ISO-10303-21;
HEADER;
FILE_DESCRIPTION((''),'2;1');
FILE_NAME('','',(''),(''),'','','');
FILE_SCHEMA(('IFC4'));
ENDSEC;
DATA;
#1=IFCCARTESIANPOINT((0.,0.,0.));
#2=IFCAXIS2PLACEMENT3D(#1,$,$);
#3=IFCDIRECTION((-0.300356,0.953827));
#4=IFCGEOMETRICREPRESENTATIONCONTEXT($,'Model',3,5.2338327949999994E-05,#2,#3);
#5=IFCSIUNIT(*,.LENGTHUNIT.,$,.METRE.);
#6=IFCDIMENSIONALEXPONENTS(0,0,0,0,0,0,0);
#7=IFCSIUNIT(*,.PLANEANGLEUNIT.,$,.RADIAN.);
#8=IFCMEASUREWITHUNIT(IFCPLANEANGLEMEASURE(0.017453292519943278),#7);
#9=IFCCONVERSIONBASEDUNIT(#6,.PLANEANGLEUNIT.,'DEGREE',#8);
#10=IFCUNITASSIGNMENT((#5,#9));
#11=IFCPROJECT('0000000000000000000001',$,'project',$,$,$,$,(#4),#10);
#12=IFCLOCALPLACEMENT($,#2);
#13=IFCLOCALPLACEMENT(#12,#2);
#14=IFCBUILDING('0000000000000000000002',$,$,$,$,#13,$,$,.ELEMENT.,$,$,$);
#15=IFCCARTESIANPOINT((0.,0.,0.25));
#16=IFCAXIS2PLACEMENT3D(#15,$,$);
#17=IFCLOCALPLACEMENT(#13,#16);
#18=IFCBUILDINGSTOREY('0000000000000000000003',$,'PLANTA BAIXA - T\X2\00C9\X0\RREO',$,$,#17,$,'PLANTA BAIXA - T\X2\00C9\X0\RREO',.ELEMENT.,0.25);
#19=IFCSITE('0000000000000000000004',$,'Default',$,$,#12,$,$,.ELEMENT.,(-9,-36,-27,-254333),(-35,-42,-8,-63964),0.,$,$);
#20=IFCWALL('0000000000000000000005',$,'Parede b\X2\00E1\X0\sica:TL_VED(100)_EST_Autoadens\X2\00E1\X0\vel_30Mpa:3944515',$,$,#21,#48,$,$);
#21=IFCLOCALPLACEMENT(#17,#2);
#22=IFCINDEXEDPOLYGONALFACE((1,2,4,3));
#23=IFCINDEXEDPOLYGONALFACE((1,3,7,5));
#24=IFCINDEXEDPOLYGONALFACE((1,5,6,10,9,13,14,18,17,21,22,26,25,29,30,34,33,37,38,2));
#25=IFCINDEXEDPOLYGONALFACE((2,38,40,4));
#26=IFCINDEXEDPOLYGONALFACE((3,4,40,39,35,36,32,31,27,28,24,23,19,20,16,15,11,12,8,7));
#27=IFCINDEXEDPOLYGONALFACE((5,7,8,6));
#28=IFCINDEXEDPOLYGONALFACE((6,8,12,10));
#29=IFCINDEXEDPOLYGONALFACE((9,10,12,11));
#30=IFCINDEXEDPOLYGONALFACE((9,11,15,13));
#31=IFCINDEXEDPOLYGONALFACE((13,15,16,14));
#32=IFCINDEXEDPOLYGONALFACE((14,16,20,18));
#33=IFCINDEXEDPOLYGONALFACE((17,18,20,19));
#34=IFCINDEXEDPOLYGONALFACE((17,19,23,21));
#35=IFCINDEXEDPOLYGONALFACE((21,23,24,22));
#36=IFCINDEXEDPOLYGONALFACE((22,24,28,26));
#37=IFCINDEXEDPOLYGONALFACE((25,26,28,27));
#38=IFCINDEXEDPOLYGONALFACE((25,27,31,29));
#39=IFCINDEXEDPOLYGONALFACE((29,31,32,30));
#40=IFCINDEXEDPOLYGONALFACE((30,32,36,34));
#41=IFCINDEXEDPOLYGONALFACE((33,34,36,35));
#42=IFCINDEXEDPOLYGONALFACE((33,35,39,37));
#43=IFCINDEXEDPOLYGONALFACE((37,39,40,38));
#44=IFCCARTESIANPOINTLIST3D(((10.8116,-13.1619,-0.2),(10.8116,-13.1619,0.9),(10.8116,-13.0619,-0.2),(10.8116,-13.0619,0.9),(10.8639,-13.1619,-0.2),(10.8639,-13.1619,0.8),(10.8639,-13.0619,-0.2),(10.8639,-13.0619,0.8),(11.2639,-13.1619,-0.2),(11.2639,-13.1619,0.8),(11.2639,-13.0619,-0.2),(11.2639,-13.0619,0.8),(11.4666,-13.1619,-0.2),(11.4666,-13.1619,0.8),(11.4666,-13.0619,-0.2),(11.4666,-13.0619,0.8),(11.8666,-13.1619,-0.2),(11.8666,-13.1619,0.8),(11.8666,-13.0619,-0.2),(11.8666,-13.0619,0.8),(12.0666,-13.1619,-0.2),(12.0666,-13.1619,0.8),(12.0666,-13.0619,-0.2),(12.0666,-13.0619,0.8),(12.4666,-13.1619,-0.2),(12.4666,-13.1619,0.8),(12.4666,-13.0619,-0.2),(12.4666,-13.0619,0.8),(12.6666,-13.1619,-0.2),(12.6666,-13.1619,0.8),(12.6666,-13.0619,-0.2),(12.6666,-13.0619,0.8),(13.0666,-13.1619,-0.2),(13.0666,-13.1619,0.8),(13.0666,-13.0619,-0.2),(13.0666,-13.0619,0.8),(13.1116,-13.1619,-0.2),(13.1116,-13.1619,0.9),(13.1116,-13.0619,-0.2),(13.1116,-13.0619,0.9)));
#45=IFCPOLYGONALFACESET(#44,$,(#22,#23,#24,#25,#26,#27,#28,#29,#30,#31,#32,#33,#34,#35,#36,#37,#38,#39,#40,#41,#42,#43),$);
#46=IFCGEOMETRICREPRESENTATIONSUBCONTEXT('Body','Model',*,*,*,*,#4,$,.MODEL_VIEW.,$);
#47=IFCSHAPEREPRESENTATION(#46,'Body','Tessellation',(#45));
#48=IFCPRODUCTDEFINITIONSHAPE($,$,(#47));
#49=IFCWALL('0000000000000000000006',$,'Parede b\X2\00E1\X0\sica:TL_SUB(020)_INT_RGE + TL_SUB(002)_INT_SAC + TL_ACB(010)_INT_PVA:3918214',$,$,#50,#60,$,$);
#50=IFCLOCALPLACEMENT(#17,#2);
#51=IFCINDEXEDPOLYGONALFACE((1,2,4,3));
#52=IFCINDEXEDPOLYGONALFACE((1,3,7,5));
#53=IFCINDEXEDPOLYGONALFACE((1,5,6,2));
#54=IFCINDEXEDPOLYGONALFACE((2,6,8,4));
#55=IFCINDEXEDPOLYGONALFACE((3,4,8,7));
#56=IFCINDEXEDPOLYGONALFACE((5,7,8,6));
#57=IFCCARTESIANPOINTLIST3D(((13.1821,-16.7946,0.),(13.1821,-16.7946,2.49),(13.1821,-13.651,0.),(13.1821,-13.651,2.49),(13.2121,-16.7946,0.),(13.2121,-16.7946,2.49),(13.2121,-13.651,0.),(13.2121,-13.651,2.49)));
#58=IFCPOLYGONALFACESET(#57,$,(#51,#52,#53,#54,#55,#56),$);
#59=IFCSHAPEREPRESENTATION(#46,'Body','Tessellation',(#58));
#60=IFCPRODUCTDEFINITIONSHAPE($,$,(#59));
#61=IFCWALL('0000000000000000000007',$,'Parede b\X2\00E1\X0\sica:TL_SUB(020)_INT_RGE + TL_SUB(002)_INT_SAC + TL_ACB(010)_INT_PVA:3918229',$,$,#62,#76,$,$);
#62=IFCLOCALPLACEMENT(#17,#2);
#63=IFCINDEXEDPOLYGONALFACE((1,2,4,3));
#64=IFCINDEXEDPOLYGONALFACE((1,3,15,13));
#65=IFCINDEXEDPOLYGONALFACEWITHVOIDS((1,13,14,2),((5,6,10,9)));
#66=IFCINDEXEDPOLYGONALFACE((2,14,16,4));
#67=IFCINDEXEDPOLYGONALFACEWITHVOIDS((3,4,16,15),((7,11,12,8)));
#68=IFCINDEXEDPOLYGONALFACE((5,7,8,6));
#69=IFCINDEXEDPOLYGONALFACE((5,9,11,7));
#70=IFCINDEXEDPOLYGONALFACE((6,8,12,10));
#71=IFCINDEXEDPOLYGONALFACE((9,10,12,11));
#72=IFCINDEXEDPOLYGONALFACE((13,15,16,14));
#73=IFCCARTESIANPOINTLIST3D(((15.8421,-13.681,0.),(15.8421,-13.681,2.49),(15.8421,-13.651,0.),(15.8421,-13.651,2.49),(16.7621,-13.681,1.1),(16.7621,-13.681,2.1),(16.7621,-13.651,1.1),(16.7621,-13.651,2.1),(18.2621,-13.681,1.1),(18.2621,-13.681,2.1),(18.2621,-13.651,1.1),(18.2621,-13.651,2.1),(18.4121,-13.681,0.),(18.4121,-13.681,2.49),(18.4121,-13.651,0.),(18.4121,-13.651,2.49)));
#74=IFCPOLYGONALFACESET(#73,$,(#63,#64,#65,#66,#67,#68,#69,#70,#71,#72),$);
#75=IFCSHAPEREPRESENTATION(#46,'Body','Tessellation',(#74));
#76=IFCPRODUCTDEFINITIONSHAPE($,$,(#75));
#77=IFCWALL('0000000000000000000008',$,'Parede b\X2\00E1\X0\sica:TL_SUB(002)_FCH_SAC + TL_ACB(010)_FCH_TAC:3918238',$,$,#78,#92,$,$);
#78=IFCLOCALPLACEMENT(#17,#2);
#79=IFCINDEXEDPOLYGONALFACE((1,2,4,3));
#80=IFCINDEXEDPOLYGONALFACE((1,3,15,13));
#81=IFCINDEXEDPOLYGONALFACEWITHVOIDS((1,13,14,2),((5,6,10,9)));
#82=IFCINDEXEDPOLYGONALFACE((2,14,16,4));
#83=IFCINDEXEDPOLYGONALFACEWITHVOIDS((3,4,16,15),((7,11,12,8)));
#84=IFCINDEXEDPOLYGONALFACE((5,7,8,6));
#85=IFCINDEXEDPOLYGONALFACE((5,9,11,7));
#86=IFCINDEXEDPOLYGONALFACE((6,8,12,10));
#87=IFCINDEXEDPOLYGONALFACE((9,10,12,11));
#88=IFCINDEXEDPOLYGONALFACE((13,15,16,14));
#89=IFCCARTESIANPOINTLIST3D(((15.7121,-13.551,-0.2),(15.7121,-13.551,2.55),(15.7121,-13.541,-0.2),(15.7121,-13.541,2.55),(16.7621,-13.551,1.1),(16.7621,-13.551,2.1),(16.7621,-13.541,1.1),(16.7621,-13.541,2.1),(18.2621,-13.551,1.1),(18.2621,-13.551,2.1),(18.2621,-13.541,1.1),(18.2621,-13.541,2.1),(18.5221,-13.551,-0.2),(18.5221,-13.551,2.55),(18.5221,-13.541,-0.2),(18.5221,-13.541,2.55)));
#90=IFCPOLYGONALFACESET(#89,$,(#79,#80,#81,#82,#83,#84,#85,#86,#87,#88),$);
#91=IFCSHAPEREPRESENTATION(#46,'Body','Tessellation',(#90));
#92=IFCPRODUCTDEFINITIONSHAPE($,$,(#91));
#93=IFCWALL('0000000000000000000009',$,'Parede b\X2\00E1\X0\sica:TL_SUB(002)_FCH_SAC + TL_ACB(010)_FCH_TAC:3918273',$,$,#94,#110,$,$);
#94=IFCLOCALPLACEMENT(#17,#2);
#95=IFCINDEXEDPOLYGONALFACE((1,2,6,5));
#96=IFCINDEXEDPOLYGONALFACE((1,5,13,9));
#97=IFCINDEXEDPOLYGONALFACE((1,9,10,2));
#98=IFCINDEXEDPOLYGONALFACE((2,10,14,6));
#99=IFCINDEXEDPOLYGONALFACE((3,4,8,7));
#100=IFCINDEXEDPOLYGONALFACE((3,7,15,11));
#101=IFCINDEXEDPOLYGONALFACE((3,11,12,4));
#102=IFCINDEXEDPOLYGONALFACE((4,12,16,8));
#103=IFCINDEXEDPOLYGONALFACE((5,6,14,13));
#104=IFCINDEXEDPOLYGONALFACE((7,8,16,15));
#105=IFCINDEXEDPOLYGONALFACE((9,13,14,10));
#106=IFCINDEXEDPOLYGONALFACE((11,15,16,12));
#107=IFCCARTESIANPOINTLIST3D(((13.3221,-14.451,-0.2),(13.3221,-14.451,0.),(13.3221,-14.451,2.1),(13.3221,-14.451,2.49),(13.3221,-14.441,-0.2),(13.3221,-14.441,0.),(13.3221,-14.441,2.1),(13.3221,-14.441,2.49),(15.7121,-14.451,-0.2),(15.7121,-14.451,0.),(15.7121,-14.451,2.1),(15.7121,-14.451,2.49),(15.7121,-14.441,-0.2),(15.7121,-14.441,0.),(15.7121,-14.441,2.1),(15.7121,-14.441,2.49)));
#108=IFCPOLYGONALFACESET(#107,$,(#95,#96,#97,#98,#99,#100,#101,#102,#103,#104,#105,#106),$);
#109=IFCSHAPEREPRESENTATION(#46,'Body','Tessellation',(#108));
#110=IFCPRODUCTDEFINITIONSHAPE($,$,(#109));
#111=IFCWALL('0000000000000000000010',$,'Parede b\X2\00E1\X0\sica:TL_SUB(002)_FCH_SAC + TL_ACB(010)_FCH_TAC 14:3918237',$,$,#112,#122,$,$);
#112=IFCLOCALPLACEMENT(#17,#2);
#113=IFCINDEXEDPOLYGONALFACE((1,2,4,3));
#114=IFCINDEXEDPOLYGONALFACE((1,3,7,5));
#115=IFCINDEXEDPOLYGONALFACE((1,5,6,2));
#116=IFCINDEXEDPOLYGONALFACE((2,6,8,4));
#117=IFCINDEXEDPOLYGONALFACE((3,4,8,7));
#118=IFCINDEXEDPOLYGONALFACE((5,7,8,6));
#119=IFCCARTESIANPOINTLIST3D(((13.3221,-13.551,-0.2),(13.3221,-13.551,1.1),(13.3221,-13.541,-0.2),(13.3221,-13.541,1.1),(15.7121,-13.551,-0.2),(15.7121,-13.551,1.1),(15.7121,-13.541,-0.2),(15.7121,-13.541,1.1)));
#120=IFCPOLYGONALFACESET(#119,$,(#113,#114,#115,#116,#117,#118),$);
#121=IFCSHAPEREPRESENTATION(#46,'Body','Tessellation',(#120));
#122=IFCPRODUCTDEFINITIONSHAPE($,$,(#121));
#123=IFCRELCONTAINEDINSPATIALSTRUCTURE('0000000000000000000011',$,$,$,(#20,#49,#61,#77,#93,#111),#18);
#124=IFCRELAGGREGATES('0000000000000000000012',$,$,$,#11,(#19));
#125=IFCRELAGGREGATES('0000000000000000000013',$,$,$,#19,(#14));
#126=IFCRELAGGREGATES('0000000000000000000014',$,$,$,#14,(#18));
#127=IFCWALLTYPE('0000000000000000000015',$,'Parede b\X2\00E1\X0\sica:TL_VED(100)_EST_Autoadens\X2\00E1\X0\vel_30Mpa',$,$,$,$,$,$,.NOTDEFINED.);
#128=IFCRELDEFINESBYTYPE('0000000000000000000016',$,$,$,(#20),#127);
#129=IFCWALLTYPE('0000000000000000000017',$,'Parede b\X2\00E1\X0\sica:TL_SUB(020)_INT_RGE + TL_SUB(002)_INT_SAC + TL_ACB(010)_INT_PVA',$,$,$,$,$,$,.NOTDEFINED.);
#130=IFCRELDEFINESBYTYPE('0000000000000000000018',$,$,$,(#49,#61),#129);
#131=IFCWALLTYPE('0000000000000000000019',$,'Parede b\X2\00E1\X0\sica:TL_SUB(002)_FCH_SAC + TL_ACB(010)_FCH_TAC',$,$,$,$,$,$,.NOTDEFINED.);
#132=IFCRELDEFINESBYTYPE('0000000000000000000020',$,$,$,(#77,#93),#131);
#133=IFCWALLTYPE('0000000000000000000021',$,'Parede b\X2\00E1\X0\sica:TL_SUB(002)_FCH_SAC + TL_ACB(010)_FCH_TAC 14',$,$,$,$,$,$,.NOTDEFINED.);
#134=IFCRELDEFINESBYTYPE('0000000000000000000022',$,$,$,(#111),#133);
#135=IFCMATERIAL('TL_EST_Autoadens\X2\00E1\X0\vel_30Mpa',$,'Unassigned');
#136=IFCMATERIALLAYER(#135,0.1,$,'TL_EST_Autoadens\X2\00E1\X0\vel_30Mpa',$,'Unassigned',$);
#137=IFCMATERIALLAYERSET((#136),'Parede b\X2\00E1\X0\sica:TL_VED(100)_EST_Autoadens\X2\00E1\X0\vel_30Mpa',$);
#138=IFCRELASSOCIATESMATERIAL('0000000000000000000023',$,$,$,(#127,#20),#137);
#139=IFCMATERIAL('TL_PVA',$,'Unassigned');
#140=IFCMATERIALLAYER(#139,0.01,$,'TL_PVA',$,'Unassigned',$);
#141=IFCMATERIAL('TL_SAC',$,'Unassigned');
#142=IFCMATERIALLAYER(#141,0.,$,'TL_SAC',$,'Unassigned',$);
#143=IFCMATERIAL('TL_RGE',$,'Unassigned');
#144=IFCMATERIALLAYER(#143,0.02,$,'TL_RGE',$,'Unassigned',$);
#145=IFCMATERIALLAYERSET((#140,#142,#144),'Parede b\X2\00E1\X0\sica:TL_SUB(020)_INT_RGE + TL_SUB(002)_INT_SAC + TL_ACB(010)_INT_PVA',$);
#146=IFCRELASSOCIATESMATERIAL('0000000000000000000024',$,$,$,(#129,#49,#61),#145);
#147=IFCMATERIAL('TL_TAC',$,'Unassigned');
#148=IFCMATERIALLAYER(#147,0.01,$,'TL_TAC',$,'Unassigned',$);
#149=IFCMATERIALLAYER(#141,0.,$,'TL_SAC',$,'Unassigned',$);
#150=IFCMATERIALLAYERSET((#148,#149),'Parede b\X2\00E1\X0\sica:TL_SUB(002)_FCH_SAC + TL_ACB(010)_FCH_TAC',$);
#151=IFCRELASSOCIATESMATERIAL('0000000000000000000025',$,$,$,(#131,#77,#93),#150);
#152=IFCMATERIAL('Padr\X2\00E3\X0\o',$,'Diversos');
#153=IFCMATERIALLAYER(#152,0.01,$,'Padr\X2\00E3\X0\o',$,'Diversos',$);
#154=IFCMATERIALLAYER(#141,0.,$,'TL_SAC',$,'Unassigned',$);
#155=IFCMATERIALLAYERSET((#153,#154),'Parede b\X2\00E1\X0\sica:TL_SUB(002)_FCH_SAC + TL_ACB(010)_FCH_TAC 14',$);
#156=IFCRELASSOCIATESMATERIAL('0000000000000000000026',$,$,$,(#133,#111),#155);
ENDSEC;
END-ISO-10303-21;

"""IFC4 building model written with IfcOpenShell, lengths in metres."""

from ifc_helpers import new_model, entity, si_unit, converted_unit, direction, frame, frame_2d, origin, place, context, subcontext, project, spatial, polyline, rectangle, extrude, clip, bounded_halfspace, material, layer, layer_set, layer_usage, type_object, element, save


model = new_model("IFC4")

# Units and contexts
model_context = context("Model", 3, precision=5.2338327949999994e-05, world=origin(), true_north=direction((-0.300356, 0.953827)))
body_context = subcontext(model_context, "Body", "Model", "MODEL_VIEW")
ifc_project = project(units=[si_unit("LENGTHUNIT", "METRE"), converted_unit("PLANEANGLEUNIT", "DEGREE", entity("IfcPlaneAngleMeasure", 0.017453292519943278), si_unit("PLANEANGLEUNIT", "RADIAN"), dimensions=[0, 0, 0, 0, 0, 0, 0])], contexts=[model_context])

# Site, building, storey
site_placement = place(None, origin())
site = spatial("IfcSite", under=ifc_project, at=site_placement, Name="Default", CompositionType="ELEMENT", RefLatitude=(-9, -36, -27, -254333), RefLongitude=(-35, -42, -8, -63964), RefElevation=0.0)
building_placement = place(site_placement, origin())
building = spatial("IfcBuilding", under=site, at=building_placement, CompositionType="ELEMENT")
storey_placement = place(building_placement, frame((0.0, 0.0, 0.25)))
storey = spatial("IfcBuildingStorey", under=building, at=storey_placement, Name="PLANTA BAIXA - TÉRREO", LongName="PLANTA BAIXA - TÉRREO", CompositionType="ELEMENT", Elevation=0.25)

# Shared definitions
ifc_material_1 = material(Name="TL_EST_Autoadensável_30Mpa", Category="Unassigned")
ifc_layer_1 = layer(ifc_material_1, 0.1, Name="TL_EST_Autoadensável_30Mpa", Category="Unassigned")
ifc_layer_set_1 = layer_set([ifc_layer_1], Name="Parede básica:TL_VED(100)_EST_Autoadensável_30Mpa")
wall_type_1 = type_object("IfcWallType", Name="Parede básica:TL_VED(100)_EST_Autoadensável_30Mpa", PredefinedType="NOTDEFINED", material=ifc_layer_set_1)

# Wall, openings
ifc_layer_usage_1 = layer_usage(ifc_layer_set_1, "AXIS2", "POSITIVE", -0.05)
wall_1_placement = place(storey_placement, frame((13.1116, -13.1119, -0.2), z_axis=(0.0, 0.0, 1.0), x_axis=(-1.0, 0.0, 0.0)))
wall_1 = element("IfcWall", 1, at=wall_1_placement, inside=storey, type_object=wall_type_1, material=ifc_layer_usage_1, Name="Parede básica:TL_VED(100)_EST_Autoadensável_30Mpa:3944515", context=body_context, shape_type="Clipping", body=[
    clip(extrude(rectangle(XDim=2.3, YDim=0.1, at=frame_2d((1.15, 0.0), x_axis=(1.0, 0.0))), origin(), (0.0, 0.0, 1.0), 1.1), bounded_halfspace(frame((0.0, -0.05, 1.1), z_axis=(0.0, 0.0, -1.0), x_axis=(-1.0, 0.0, 0.0)), True, frame((0.0, -0.05, 1.1)), polyline([(0.0, 0.0), (2.3, 0.0), (2.3, 0.05), (2.3, 0.1), (1.8027, 0.1), (1.7027, 0.1), (1.2, 0.1), (1.1, 0.1), (0.6, 0.1), (0.5, 0.1), (0.0, 0.1), (0.0, 0.0)]))),
])
opening_1_placement = place(wall_1_placement, frame((13.1116, -13.1119, 0.0), z_axis=(0.0, 0.0, 1.0), x_axis=(-1.0, 0.0, 0.0)))
element("IfcOpeningElement", 2, at=opening_1_placement, cuts=wall_1, PredefinedType="OPENING", context=body_context, shape_type="SweptSolid", body=[
    extrude(rectangle(XDim=1.0, YDim=0.4, at=frame_2d((0.0, 0.0), x_axis=(0.0, 1.0))), frame((11.0639, -12.3546, 0.5), z_axis=(0.0, -1.0, 0.0), x_axis=(-1.0, 0.0, 0.0)), (0.0, 0.0, 1.0), 1.542),
])
opening_2_placement = place(wall_1_placement, frame((13.1116, -13.1119, 0.0), z_axis=(0.0, 0.0, 1.0), x_axis=(-1.0, 0.0, 0.0)))
element("IfcOpeningElement", 3, at=opening_2_placement, cuts=wall_1, PredefinedType="OPENING", context=body_context, shape_type="SweptSolid", body=[
    extrude(rectangle(XDim=1.0, YDim=0.4, at=frame_2d((0.0, 0.0), x_axis=(0.0, 1.0))), frame((11.6666, -12.3546, 0.5), z_axis=(0.0, -1.0, 0.0), x_axis=(-1.0, 0.0, 0.0)), (0.0, 0.0, 1.0), 1.542),
])
opening_3_placement = place(wall_1_placement, frame((13.1116, -13.1119, 0.0), z_axis=(0.0, 0.0, 1.0), x_axis=(-1.0, 0.0, 0.0)))
element("IfcOpeningElement", 4, at=opening_3_placement, cuts=wall_1, PredefinedType="OPENING", context=body_context, shape_type="SweptSolid", body=[
    extrude(rectangle(XDim=1.0, YDim=0.4, at=frame_2d((0.0, 0.0), x_axis=(0.0, 1.0))), frame((12.2666, -12.3546, 0.5), z_axis=(0.0, -1.0, 0.0), x_axis=(-1.0, 0.0, 0.0)), (0.0, 0.0, 1.0), 1.542),
])
opening_4_placement = place(wall_1_placement, frame((13.1116, -13.1119, 0.0), z_axis=(0.0, 0.0, 1.0), x_axis=(-1.0, 0.0, 0.0)))
element("IfcOpeningElement", 5, at=opening_4_placement, cuts=wall_1, PredefinedType="OPENING", context=body_context, shape_type="SweptSolid", body=[
    extrude(rectangle(XDim=1.0, YDim=0.4, at=frame_2d((0.0, 0.0), x_axis=(0.0, 1.0))), frame((12.8666, -12.3546, 0.5), z_axis=(0.0, -1.0, 0.0), x_axis=(-1.0, 0.0, 0.0)), (0.0, 0.0, 1.0), 1.542),
])

# Wall
ifc_material_2 = material(Name="TL_PVA", Category="Unassigned")
ifc_layer_2 = layer(ifc_material_2, 0.01, Name="TL_PVA", Category="Unassigned")
ifc_material_3 = material(Name="TL_SAC", Category="Unassigned")
ifc_layer_3 = layer(ifc_material_3, 0.0, Name="TL_SAC", Category="Unassigned")
ifc_material_4 = material(Name="TL_RGE", Category="Unassigned")
ifc_layer_4 = layer(ifc_material_4, 0.02, Name="TL_RGE", Category="Unassigned")
ifc_layer_set_2 = layer_set([ifc_layer_2, ifc_layer_3, ifc_layer_4], Name="Parede básica:TL_SUB(020)_INT_RGE + TL_SUB(002)_INT_SAC + TL_ACB(010)_INT_PVA")
ifc_layer_usage_2 = layer_usage(ifc_layer_set_2, "AXIS2", "POSITIVE", -0.015)
wall_type_2 = type_object("IfcWallType", Name="Parede básica:TL_SUB(020)_INT_RGE + TL_SUB(002)_INT_SAC + TL_ACB(010)_INT_PVA", PredefinedType="NOTDEFINED", material=ifc_layer_set_2)
wall_2_placement = place(storey_placement, frame((13.1971, -13.651, 0.0), z_axis=(0.0, 0.0, 1.0), x_axis=(0.0, -1.0, 0.0)))
element("IfcWall", 6, at=wall_2_placement, inside=storey, type_object=wall_type_2, material=ifc_layer_usage_2, Name="Parede básica:TL_SUB(020)_INT_RGE + TL_SUB(002)_INT_SAC + TL_ACB(010)_INT_PVA:3918214", context=body_context, shape_type="SweptSolid", body=[
    extrude(rectangle(XDim=3.1437, YDim=0.03, at=frame_2d((1.5718, 0.0), x_axis=(-1.0, 0.0))), origin(), (0.0, 0.0, 1.0), 2.49),
])

# Walls, openings
ifc_layer_usage_3 = layer_usage(ifc_layer_set_2, "AXIS2", "POSITIVE", -0.015)
wall_3_placement = place(storey_placement, frame((15.8421, -13.666, 0.0)))
wall_3 = element("IfcWall", 7, at=wall_3_placement, inside=storey, type_object=wall_type_2, material=ifc_layer_usage_3, Name="Parede básica:TL_SUB(020)_INT_RGE + TL_SUB(002)_INT_SAC + TL_ACB(010)_INT_PVA:3918229", context=body_context, shape_type="SweptSolid", body=[
    extrude(rectangle(XDim=2.57, YDim=0.03, at=frame_2d((1.285, 0.0), x_axis=(-1.0, 0.0))), origin(), (0.0, 0.0, 1.0), 2.49),
])
opening_5_placement = place(wall_3_placement, frame((-15.8421, 13.666, 1.1)))
element("IfcOpeningElement", 8, at=opening_5_placement, cuts=wall_3, PredefinedType="OPENING", context=body_context, shape_type="SweptSolid", body=[
    extrude(rectangle(XDim=1.0, YDim=1.5, at=frame_2d((0.0, 0.0), x_axis=(0.0, 1.0))), frame((17.5121, -15.175, 0.5), z_axis=(0.0, 1.0, 0.0), x_axis=(1.0, 0.0, 0.0)), (0.0, 0.0, 1.0), 3.048),
])
ifc_material_5 = material(Name="TL_TAC", Category="Unassigned")
ifc_layer_5 = layer(ifc_material_5, 0.01, Name="TL_TAC", Category="Unassigned")
ifc_layer_6 = layer(ifc_material_3, 0.0, Name="TL_SAC", Category="Unassigned")
ifc_layer_set_3 = layer_set([ifc_layer_5, ifc_layer_6], Name="Parede básica:TL_SUB(002)_FCH_SAC + TL_ACB(010)_FCH_TAC")
ifc_layer_usage_4 = layer_usage(ifc_layer_set_3, "AXIS2", "NEGATIVE", 0.005)
wall_type_3 = type_object("IfcWallType", Name="Parede básica:TL_SUB(002)_FCH_SAC + TL_ACB(010)_FCH_TAC", PredefinedType="NOTDEFINED", material=ifc_layer_set_3)
wall_4_placement = place(storey_placement, frame((15.7121, -13.546, -0.2)))
wall_4 = element("IfcWall", 9, at=wall_4_placement, inside=storey, type_object=wall_type_3, material=ifc_layer_usage_4, Name="Parede básica:TL_SUB(002)_FCH_SAC + TL_ACB(010)_FCH_TAC:3918238", context=body_context, shape_type="SweptSolid", body=[
    extrude(rectangle(XDim=2.81, YDim=0.01, at=frame_2d((1.405, 0.0), x_axis=(-1.0, 0.0))), origin(), (0.0, 0.0, 1.0), 2.75),
])
opening_6_placement = place(wall_4_placement, frame((-15.7121, 13.546, 1.3)))
element("IfcOpeningElement", 10, at=opening_6_placement, cuts=wall_4, PredefinedType="OPENING", context=body_context, shape_type="SweptSolid", body=[
    extrude(rectangle(XDim=1.0, YDim=1.5, at=frame_2d((0.0, 0.0), x_axis=(0.0, 1.0))), frame((17.5121, -15.175, 0.5), z_axis=(0.0, 1.0, 0.0), x_axis=(1.0, 0.0, 0.0)), (0.0, 0.0, 1.0), 3.048),
])
ifc_layer_usage_5 = layer_usage(ifc_layer_set_3, "AXIS2", "NEGATIVE", 0.005)
wall_5_placement = place(storey_placement, frame((13.3221, -14.446, -0.2)))
wall_5 = element("IfcWall", 11, at=wall_5_placement, inside=storey, type_object=wall_type_3, material=ifc_layer_usage_5, Name="Parede básica:TL_SUB(002)_FCH_SAC + TL_ACB(010)_FCH_TAC:3918273", context=body_context, shape_type="SweptSolid", body=[
    extrude(rectangle(XDim=2.39, YDim=0.01, at=frame_2d((1.195, 0.0), x_axis=(-1.0, 0.0))), origin(), (0.0, 0.0, 1.0), 2.69),
])
opening_7_placement = place(wall_5_placement, frame((-13.3221, 14.446, 0.2)))
element("IfcOpeningElement", 12, at=opening_7_placement, cuts=wall_5, PredefinedType="OPENING", context=body_context, shape_type="SweptSolid", body=[
    extrude(rectangle(XDim=2.1, YDim=2.4, at=frame_2d((0.0, 0.0), x_axis=(0.0, 1.0))), frame((14.5121, -15.975, 1.05), z_axis=(0.0, 1.0, 0.0), x_axis=(-1.0, 0.0, 0.0)), (0.0, 0.0, 1.0), 3.048),
])

# Wall
ifc_material_6 = material(Name="Padrão", Category="Diversos")
ifc_layer_7 = layer(ifc_material_6, 0.01, Name="Padrão", Category="Diversos")
ifc_layer_8 = layer(ifc_material_3, 0.0, Name="TL_SAC", Category="Unassigned")
ifc_layer_set_4 = layer_set([ifc_layer_7, ifc_layer_8], Name="Parede básica:TL_SUB(002)_FCH_SAC + TL_ACB(010)_FCH_TAC 14")
ifc_layer_usage_6 = layer_usage(ifc_layer_set_4, "AXIS2", "POSITIVE", -0.005)
wall_type_4 = type_object("IfcWallType", Name="Parede básica:TL_SUB(002)_FCH_SAC + TL_ACB(010)_FCH_TAC 14", PredefinedType="NOTDEFINED", material=ifc_layer_set_4)
wall_6_placement = place(storey_placement, frame((13.3221, -13.546, -0.2)))
element("IfcWall", 13, at=wall_6_placement, inside=storey, type_object=wall_type_4, material=ifc_layer_usage_6, Name="Parede básica:TL_SUB(002)_FCH_SAC + TL_ACB(010)_FCH_TAC 14:3918237", context=body_context, shape_type="SweptSolid", body=[
    extrude(rectangle(XDim=2.39, YDim=0.01, at=frame_2d((1.195, 0.0), x_axis=(-1.0, 0.0))), origin(), (0.0, 0.0, 1.0), 1.3),
])

save(model, "model.ifc")
